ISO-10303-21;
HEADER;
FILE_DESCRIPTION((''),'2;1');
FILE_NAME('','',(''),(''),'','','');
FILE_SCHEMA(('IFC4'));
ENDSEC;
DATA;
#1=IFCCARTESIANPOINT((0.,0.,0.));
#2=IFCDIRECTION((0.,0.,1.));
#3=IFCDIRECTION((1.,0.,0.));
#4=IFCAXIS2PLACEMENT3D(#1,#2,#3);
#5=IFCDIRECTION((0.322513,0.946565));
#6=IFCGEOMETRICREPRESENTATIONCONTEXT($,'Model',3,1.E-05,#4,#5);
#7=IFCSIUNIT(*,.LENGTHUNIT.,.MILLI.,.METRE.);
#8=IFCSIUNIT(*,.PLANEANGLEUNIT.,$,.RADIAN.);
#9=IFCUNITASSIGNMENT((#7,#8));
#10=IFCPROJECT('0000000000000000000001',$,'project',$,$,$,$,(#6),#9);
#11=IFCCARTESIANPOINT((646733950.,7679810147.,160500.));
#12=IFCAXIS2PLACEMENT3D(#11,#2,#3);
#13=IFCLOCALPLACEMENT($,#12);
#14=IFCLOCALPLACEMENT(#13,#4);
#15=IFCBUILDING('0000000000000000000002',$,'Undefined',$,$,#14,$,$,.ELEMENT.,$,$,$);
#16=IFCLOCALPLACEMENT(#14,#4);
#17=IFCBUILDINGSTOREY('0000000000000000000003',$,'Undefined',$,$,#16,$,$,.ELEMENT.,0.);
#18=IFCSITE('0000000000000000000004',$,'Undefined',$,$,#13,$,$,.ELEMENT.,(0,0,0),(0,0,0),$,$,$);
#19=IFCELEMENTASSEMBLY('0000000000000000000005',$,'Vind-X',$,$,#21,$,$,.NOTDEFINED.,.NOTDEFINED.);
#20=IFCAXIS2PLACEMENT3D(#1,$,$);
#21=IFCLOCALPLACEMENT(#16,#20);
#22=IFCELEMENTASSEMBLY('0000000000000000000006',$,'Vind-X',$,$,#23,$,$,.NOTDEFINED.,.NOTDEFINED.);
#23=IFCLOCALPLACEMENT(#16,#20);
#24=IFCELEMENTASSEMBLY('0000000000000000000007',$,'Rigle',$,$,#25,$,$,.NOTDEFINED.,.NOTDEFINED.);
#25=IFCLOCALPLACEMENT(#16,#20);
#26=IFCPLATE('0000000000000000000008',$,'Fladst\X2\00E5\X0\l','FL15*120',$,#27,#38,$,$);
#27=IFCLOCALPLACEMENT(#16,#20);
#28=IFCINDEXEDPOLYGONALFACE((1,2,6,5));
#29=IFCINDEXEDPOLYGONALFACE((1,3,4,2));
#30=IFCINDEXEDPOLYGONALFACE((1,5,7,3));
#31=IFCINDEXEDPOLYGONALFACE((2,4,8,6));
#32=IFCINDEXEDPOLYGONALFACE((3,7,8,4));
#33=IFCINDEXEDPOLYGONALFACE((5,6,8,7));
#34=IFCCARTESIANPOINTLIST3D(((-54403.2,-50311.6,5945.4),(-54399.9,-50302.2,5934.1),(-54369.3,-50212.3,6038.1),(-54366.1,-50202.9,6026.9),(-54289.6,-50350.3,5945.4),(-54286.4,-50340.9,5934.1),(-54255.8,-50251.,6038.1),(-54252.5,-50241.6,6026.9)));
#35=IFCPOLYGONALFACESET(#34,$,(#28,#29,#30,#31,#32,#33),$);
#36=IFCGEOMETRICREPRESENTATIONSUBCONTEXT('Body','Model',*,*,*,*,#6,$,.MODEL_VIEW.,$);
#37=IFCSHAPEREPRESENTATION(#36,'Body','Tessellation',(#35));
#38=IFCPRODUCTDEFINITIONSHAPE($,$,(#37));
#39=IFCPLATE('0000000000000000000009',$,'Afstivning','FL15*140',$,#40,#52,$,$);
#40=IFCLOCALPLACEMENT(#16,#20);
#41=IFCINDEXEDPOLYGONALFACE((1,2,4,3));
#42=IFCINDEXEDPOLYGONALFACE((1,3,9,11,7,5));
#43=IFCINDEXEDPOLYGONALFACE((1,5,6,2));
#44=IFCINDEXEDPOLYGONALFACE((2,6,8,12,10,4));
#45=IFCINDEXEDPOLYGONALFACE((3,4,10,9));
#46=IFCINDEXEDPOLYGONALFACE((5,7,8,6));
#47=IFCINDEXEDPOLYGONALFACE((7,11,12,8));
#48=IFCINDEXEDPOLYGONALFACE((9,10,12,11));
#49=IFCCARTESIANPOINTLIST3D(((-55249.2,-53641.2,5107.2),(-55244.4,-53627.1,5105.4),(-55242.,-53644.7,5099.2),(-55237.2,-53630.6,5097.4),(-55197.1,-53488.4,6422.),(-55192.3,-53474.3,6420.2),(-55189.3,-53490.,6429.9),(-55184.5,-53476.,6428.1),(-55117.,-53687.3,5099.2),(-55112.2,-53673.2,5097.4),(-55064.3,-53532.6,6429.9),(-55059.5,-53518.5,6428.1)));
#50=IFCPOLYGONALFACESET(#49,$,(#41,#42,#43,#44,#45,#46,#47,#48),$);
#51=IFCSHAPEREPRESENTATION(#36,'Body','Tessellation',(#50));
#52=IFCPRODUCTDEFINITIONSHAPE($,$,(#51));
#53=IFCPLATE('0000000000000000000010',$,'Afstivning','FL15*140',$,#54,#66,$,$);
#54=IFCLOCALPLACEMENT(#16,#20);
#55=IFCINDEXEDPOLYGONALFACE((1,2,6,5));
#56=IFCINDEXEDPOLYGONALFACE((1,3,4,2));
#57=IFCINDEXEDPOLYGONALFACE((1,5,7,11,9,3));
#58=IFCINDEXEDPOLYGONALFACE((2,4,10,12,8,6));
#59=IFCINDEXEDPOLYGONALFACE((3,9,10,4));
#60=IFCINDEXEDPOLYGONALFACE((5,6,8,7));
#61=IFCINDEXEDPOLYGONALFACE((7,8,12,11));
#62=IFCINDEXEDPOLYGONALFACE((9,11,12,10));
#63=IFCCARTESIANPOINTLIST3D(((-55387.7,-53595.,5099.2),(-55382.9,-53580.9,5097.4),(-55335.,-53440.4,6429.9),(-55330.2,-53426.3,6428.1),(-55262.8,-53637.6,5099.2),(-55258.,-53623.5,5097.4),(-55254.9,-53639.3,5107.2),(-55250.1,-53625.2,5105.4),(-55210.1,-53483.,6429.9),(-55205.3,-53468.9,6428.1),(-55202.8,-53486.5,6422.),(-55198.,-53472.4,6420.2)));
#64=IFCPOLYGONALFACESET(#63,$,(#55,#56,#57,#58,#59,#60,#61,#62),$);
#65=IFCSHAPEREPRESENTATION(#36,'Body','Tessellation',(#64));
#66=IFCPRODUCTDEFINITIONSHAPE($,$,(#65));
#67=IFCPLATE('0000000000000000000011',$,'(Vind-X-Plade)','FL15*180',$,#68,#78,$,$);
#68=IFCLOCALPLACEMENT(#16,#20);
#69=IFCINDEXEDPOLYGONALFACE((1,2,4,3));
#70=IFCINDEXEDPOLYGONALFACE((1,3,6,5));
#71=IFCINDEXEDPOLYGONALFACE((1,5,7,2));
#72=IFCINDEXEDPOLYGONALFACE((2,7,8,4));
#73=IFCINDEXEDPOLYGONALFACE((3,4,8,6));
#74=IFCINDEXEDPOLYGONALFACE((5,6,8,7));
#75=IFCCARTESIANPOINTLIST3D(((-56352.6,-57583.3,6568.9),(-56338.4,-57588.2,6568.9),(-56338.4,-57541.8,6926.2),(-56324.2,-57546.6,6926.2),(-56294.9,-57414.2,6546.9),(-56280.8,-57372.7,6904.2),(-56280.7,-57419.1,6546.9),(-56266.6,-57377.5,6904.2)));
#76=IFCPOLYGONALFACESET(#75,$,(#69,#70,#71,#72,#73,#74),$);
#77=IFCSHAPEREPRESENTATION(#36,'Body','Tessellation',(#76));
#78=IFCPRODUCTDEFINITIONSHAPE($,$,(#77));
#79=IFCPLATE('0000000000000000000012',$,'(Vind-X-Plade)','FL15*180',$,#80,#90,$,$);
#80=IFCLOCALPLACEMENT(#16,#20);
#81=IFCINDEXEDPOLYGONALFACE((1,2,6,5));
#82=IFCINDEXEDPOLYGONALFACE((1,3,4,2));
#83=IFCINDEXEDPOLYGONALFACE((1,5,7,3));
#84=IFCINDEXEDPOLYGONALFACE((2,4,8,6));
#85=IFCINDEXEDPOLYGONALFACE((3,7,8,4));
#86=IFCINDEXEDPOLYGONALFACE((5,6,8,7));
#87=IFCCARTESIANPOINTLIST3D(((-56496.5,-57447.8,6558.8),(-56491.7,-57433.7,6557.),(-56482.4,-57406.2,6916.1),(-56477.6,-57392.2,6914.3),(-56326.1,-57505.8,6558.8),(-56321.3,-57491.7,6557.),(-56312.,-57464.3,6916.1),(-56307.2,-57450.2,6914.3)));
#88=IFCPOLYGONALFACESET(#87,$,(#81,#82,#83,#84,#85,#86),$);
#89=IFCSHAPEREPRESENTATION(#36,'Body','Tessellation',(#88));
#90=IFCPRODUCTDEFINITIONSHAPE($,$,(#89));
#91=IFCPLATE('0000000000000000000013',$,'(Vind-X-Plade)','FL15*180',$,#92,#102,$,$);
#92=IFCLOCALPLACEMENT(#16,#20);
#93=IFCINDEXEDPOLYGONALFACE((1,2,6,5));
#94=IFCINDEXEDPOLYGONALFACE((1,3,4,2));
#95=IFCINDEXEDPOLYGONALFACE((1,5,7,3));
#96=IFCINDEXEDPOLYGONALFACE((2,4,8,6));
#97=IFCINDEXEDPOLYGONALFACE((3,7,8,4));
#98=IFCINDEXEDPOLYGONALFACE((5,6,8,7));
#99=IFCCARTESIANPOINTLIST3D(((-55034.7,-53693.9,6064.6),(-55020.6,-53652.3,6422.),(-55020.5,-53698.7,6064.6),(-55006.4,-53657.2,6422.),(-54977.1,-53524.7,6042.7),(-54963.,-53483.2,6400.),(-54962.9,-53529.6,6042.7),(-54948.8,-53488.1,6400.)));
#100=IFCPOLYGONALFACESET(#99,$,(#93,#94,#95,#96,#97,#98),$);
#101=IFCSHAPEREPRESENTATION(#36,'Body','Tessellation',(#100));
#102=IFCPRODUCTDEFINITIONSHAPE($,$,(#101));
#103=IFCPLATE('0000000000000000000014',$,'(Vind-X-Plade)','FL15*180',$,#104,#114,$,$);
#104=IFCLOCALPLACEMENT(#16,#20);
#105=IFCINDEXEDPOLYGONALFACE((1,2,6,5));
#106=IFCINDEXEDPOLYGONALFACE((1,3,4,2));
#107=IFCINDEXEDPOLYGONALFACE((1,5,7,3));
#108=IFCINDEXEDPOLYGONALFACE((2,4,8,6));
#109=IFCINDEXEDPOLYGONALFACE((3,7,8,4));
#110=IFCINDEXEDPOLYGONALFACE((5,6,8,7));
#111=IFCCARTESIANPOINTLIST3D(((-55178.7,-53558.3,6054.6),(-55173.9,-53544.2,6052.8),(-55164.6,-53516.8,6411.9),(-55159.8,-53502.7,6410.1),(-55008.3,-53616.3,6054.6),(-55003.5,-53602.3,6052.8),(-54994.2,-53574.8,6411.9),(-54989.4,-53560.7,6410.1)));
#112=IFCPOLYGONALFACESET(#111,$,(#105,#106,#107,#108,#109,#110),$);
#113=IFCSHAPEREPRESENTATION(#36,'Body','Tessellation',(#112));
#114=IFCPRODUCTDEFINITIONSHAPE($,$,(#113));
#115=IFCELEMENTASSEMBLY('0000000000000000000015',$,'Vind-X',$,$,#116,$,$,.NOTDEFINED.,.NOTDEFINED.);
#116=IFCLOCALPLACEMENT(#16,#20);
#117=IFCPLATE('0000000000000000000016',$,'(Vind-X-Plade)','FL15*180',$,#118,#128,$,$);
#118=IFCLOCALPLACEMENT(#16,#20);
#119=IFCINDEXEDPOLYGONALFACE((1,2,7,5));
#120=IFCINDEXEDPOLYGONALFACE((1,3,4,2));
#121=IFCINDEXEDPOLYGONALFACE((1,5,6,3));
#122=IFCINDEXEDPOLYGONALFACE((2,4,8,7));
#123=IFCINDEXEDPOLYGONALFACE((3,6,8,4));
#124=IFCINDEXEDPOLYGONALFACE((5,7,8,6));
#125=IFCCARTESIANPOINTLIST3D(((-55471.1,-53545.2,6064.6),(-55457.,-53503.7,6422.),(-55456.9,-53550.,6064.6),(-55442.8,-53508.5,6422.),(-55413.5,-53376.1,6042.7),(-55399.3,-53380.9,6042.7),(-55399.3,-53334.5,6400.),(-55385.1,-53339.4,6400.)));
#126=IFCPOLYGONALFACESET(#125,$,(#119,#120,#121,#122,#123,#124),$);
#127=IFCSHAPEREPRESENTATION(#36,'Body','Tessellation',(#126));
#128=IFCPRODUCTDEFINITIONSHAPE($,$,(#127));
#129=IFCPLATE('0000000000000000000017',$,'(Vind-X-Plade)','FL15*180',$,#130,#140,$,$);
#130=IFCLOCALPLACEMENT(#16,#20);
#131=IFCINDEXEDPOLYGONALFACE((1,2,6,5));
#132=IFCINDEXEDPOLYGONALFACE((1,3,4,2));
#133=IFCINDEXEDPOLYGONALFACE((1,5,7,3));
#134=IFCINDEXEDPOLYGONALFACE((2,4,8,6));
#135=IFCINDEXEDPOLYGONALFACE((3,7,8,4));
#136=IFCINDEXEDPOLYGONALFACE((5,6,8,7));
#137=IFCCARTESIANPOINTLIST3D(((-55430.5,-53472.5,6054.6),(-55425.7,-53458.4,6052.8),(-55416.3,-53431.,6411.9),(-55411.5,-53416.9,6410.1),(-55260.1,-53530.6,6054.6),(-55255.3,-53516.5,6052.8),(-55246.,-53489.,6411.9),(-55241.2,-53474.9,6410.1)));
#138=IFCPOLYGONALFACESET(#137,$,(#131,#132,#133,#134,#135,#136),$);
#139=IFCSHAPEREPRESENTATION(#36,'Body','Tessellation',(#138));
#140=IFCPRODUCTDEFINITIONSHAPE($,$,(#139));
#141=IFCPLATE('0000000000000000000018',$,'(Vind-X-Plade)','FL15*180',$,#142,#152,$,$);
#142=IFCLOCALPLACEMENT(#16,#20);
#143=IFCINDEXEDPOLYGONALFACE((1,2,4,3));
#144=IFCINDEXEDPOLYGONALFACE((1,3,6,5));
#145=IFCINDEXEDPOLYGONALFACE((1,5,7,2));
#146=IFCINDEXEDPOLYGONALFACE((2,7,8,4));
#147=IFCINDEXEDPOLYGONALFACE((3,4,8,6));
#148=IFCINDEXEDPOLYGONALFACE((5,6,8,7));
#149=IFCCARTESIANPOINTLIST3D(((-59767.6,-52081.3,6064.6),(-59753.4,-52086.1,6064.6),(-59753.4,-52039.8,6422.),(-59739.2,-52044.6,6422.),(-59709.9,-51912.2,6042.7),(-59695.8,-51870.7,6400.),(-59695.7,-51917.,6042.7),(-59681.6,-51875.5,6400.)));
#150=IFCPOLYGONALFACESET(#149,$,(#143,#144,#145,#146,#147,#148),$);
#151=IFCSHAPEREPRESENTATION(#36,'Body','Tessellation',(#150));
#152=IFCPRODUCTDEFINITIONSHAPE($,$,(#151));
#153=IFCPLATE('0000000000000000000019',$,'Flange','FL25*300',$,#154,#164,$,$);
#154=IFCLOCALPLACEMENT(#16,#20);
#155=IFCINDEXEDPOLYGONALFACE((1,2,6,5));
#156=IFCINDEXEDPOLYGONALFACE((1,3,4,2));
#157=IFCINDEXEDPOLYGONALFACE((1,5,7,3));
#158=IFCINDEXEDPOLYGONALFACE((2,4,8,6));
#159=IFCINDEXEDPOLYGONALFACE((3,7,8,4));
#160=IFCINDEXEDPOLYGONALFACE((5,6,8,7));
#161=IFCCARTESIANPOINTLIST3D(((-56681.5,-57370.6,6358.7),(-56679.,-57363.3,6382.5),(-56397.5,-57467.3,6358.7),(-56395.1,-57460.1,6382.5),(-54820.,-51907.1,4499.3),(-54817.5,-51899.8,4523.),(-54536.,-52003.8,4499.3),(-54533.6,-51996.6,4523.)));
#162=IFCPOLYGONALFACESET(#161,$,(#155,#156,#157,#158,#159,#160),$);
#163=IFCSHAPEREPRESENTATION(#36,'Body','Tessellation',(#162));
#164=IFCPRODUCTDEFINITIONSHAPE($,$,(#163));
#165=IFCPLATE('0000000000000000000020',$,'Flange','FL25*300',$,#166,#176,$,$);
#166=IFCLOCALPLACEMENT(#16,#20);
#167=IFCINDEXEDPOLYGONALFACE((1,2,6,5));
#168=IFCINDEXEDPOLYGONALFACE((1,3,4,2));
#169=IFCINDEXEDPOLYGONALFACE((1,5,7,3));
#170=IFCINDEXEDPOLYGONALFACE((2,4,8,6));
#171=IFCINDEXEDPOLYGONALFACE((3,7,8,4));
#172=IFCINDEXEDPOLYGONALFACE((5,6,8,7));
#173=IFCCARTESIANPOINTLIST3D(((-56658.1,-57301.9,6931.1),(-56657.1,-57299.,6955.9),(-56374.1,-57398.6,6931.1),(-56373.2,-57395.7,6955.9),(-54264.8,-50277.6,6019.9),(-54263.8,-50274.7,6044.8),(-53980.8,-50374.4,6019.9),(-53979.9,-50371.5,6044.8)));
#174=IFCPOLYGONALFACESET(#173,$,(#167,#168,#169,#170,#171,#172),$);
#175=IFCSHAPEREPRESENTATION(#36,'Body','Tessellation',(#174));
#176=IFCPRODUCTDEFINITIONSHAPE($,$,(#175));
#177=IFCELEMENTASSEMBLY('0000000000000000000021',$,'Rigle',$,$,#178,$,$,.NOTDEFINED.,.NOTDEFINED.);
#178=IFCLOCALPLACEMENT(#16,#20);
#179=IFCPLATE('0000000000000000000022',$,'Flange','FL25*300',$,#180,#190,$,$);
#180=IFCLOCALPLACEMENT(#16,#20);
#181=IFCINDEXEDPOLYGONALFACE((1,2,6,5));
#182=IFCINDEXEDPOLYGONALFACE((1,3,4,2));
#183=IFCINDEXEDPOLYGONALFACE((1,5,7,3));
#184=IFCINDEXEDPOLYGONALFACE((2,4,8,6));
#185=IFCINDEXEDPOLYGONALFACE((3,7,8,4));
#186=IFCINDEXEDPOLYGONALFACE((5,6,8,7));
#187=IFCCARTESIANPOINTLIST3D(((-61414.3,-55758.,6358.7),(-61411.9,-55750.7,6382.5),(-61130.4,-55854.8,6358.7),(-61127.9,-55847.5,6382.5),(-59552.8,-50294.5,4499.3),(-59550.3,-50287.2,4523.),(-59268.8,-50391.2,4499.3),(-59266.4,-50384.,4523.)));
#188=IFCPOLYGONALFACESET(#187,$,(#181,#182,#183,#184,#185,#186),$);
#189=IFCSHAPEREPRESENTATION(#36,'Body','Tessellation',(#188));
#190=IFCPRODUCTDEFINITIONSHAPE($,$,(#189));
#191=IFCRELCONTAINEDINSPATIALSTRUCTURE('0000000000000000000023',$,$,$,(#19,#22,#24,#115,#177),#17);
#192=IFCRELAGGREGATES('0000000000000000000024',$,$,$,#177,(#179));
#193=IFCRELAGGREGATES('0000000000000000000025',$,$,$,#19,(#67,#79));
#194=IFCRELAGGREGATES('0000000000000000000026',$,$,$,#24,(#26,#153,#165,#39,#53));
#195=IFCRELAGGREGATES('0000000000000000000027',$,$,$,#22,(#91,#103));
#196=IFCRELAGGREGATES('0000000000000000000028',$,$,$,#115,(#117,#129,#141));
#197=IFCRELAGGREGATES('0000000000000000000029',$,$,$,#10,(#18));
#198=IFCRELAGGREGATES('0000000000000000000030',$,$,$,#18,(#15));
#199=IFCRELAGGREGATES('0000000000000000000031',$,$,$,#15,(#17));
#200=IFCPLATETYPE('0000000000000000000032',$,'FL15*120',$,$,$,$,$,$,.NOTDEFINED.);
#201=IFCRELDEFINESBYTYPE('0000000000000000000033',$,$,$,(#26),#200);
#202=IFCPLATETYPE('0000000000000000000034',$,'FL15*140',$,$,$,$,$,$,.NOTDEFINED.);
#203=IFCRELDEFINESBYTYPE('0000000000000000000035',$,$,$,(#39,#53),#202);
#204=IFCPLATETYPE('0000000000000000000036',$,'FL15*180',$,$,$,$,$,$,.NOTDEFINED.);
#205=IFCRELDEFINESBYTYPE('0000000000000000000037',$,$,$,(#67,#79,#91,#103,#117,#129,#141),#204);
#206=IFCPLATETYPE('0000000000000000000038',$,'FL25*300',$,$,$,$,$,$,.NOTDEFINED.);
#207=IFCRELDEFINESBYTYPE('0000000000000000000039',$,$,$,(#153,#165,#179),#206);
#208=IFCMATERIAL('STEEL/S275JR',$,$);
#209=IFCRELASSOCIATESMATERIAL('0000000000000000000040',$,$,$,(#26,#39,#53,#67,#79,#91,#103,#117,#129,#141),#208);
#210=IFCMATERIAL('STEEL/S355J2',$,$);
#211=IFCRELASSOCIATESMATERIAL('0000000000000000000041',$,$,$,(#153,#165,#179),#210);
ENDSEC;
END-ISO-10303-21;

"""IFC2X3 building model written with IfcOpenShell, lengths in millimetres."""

from ifc_helpers import new_model, si_unit, direction, frame, origin_with_axes, place, context, subcontext, project, spatial, polyline, outline, extrude, clip, halfspace, material, type_object, element, aggregate, save


model = new_model("IFC2X3")

# Units and contexts
model_context = context("Model", 3, precision=1e-05, world=origin_with_axes(), true_north=direction((0.322513, 0.946565)))
body_context = subcontext(model_context, "Body", "Model", "MODEL_VIEW")
ifc_project = project(units=[si_unit("LENGTHUNIT", "METRE", prefix="MILLI"), si_unit("PLANEANGLEUNIT", "RADIAN")], contexts=[model_context])

# Site, building, storey
site_placement = place(None, frame((646733950.0, 7679810147.0, 160500.0), z_axis=(0.0, 0.0, 1.0), x_axis=(1.0, 0.0, 0.0)))
site = spatial("IfcSite", under=ifc_project, at=site_placement, Name="Undefined", CompositionType="ELEMENT", RefLatitude=(0, 0, 0), RefLongitude=(0, 0, 0))
building_placement = place(site_placement, origin_with_axes())
building = spatial("IfcBuilding", under=site, at=building_placement, Name="Undefined", CompositionType="ELEMENT")
storey_placement = place(building_placement, origin_with_axes())
storey = spatial("IfcBuildingStorey", under=building, at=storey_placement, Name="Undefined", CompositionType="ELEMENT", Elevation=0.0)

# Element assemblies
assembly_1_placement = place(storey_placement, origin_with_axes())
assembly_1 = element("IfcElementAssembly", 1, at=assembly_1_placement, inside=storey, Name="Vind-X", AssemblyPlace="NOTDEFINED", PredefinedType="NOTDEFINED")
assembly_2_placement = place(storey_placement, origin_with_axes())
assembly_2 = element("IfcElementAssembly", 2, at=assembly_2_placement, inside=storey, Name="Vind-X", AssemblyPlace="NOTDEFINED", PredefinedType="NOTDEFINED")

# Shared definitions
ifc_material_1 = material(Name="STEEL/S355J2")

# Element assembly
assembly_3_placement = place(storey_placement, origin_with_axes())
assembly_3 = element("IfcElementAssembly", 3, at=assembly_3_placement, inside=storey, Name="Rigle", AssemblyPlace="NOTDEFINED", PredefinedType="NOTDEFINED")

# Plates
ifc_material_2 = material(Name="STEEL/S275JR")
plate_type_1 = type_object("IfcPlateType", Name="FL15*120", PredefinedType="NOTDEFINED")
plate_1_placement = place(assembly_3_placement, frame((-54288.0, -50345.6, 5939.7), z_axis=(-0.213703, -0.627213, 0.748956), x_axis=(0.241548, 0.708935, 0.66262)))
plate_1 = element("IfcPlate", 4, at=plate_1_placement, type_object=plate_type_1, material=ifc_material_2, Name="Fladstål", Description="FL15*120", context=body_context, shape_type="SweptSolid", body=[
    extrude(outline(polyline([(0.0, 0.0), (140.0, 0.0), (140.0, 120.0), (0.0, 120.0), (0.0, 0.0)])), frame((0.0, 0.0, -7.5), z_axis=(0.0, 0.0, 1.0), x_axis=(1.0, 0.0, 0.0)), (0.0, 0.0, 1.0), 15.0),
])
plate_type_2 = type_object("IfcPlateType", Name="FL15*140", PredefinedType="NOTDEFINED")
plate_2_placement = place(assembly_3_placement, frame((-55114.6, -53680.2, 5098.3), z_axis=(0.320109, 0.93951, -0.121869), x_axis=(-0.946565, 0.322513, 0.0)))
plate_2 = element("IfcPlate", 5, at=plate_2_placement, type_object=plate_type_2, material=ifc_material_2, Name="Afstivning", Description="FL15*140", context=body_context, shape_type="SweptSolid", body=[
    extrude(outline(polyline([(0.0, 0.0), (132.0, 0.0), (140.0, 8.0), (140.0, 1332.7), (132.0, 1340.7), (0.0, 1340.7), (0.0, 0.0)])), frame((0.0, 0.0, -7.5), z_axis=(0.0, 0.0, 1.0), x_axis=(1.0, 0.0, 0.0)), (0.0, 0.0, 1.0), 15.0),
])
plate_3_placement = place(assembly_3_placement, frame((-55252.8, -53633.1, 5098.3), z_axis=(0.320109, 0.93951, -0.121869), x_axis=(-0.946565, 0.322513, 0.0)))
plate_3 = element("IfcPlate", 6, at=plate_3_placement, type_object=plate_type_2, material=ifc_material_2, Name="Afstivning", Description="FL15*140", context=body_context, shape_type="SweptSolid", body=[
    extrude(outline(polyline([(0.0, 8.0), (8.0, 0.0), (140.0, 0.0), (140.0, 1340.7), (8.0, 1340.7), (0.0, 1332.7), (0.0, 8.0)])), frame((0.0, 0.0, -7.5), z_axis=(0.0, 0.0, 1.0), x_axis=(1.0, 0.0, 0.0)), (0.0, 0.0, 1.0), 15.0),
])
plate_type_3 = type_object("IfcPlateType", Name="FL15*180", PredefinedType="NOTDEFINED")
plate_4_placement = place(assembly_1_placement, frame((-56331.3, -57544.2, 6926.2), z_axis=(-0.946565, 0.322513, 0.0), x_axis=(0.320109, 0.93951, -0.121869)))
plate_4 = element("IfcPlate", 7, at=plate_4_placement, type_object=plate_type_3, material=ifc_material_2, Name="(Vind-X-Plade)", Description="FL15*180", context=body_context, shape_type="SweptSolid", body=[
    extrude(outline(polyline([(0.0, 0.0), (180.0, 0.0), (180.0, 360.0), (0.0, 360.0), (0.0, 0.0)])), frame((0.0, 0.0, -7.5), z_axis=(0.0, 0.0, 1.0), x_axis=(1.0, 0.0, 0.0)), (0.0, 0.0, 1.0), 15.0),
])
plate_5_placement = place(assembly_1_placement, frame((-56494.1, -57440.7, 6557.9), z_axis=(0.320109, 0.93951, -0.121869), x_axis=(0.039304, 0.115357, 0.992546)))
plate_5 = element("IfcPlate", 8, at=plate_5_placement, type_object=plate_type_3, material=ifc_material_2, Name="(Vind-X-Plade)", Description="FL15*180", context=body_context, shape_type="SweptSolid", body=[
    extrude(outline(polyline([(0.0, 0.0), (360.0, 0.0), (360.0, 180.0), (0.0, 180.0), (0.0, 0.0)])), frame((0.0, 0.0, -7.5), z_axis=(0.0, 0.0, 1.0), x_axis=(1.0, 0.0, 0.0)), (0.0, 0.0, 1.0), 15.0),
])
plate_6_placement = place(assembly_2_placement, frame((-55013.5, -53654.7, 6422.0), z_axis=(-0.946565, 0.322513, 0.0), x_axis=(0.320109, 0.93951, -0.121869)))
plate_6 = element("IfcPlate", 9, at=plate_6_placement, type_object=plate_type_3, material=ifc_material_2, Name="(Vind-X-Plade)", Description="FL15*180", context=body_context, shape_type="SweptSolid", body=[
    extrude(outline(polyline([(0.0, 0.0), (180.0, 0.0), (180.0, 360.0), (0.0, 360.0), (0.0, 0.0)])), frame((0.0, 0.0, -7.5), z_axis=(0.0, 0.0, 1.0), x_axis=(1.0, 0.0, 0.0)), (0.0, 0.0, 1.0), 15.0),
])
plate_7_placement = place(assembly_2_placement, frame((-55176.3, -53551.2, 6053.7), z_axis=(0.320109, 0.93951, -0.121869), x_axis=(0.039304, 0.115357, 0.992546)))
plate_7 = element("IfcPlate", 10, at=plate_7_placement, type_object=plate_type_3, material=ifc_material_2, Name="(Vind-X-Plade)", Description="FL15*180", context=body_context, shape_type="SweptSolid", body=[
    extrude(outline(polyline([(0.0, 0.0), (360.0, 0.0), (360.0, 180.0), (0.0, 180.0), (0.0, 0.0)])), frame((0.0, 0.0, -7.5), z_axis=(0.0, 0.0, 1.0), x_axis=(1.0, 0.0, 0.0)), (0.0, 0.0, 1.0), 15.0),
])

# Element assembly, plates
assembly_4_placement = place(storey_placement, origin_with_axes())
assembly_4 = element("IfcElementAssembly", 11, at=assembly_4_placement, inside=storey, Name="Vind-X", AssemblyPlace="NOTDEFINED", PredefinedType="NOTDEFINED")
plate_8_placement = place(assembly_4_placement, frame((-55392.2, -53337.0, 6400.0), z_axis=(0.946565, -0.322513, 0.0), x_axis=(-0.320109, -0.93951, 0.121869)))
plate_8 = element("IfcPlate", 12, at=plate_8_placement, type_object=plate_type_3, material=ifc_material_2, Name="(Vind-X-Plade)", Description="FL15*180", context=body_context, shape_type="SweptSolid", body=[
    extrude(outline(polyline([(0.0, 0.0), (180.0, 0.0), (180.0, 360.0), (0.0, 360.0), (0.0, 0.0)])), frame((0.0, 0.0, -7.5), z_axis=(0.0, 0.0, 1.0), x_axis=(1.0, 0.0, 0.0)), (0.0, 0.0, 1.0), 15.0),
])
plate_9_placement = place(assembly_4_placement, frame((-55257.7, -53523.5, 6053.7), z_axis=(-0.320109, -0.93951, 0.121869), x_axis=(0.039304, 0.115357, 0.992546)))
plate_9 = element("IfcPlate", 13, at=plate_9_placement, type_object=plate_type_3, material=ifc_material_2, Name="(Vind-X-Plade)", Description="FL15*180", context=body_context, shape_type="SweptSolid", body=[
    extrude(outline(polyline([(0.0, 0.0), (360.0, 0.0), (360.0, 180.0), (0.0, 180.0), (0.0, 0.0)])), frame((0.0, 0.0, -7.5), z_axis=(0.0, 0.0, 1.0), x_axis=(1.0, 0.0, 0.0)), (0.0, 0.0, 1.0), 15.0),
])
plate_10_placement = place(assembly_4_placement, frame((-59746.3, -52042.2, 6422.0), z_axis=(-0.946565, 0.322513, 0.0), x_axis=(0.320109, 0.93951, -0.121869)))
plate_10 = element("IfcPlate", 14, at=plate_10_placement, type_object=plate_type_3, material=ifc_material_2, Name="(Vind-X-Plade)", Description="FL15*180", context=body_context, shape_type="SweptSolid", body=[
    extrude(outline(polyline([(0.0, 0.0), (180.0, 0.0), (180.0, 360.0), (0.0, 360.0), (0.0, 0.0)])), frame((0.0, 0.0, -7.5), z_axis=(0.0, 0.0, 1.0), x_axis=(1.0, 0.0, 0.0)), (0.0, 0.0, 1.0), 15.0),
])

# Plates
plate_type_4 = type_object("IfcPlateType", Name="FL25*300", PredefinedType="NOTDEFINED")
plate_11_placement = place(assembly_3_placement, frame((-54676.8, -51951.8, 4511.2), z_axis=(-0.098895, -0.290253, -0.951826), x_axis=(-0.306976, -0.900965, 0.306638)))
plate_11 = element("IfcPlate", 15, at=plate_11_placement, type_object=plate_type_4, material=ifc_material_1, Name="Flange", Description="FL25*300", context=body_context, shape_type="Clipping", body=[
    clip(extrude(outline(polyline([(0.0, -150.0), (0.0, 150.0), (6064.1, 150.0), (6064.1, -150.0), (0.0, -150.0)])), frame((0.0, 0.0, -12.5), z_axis=(0.0, 0.0, 1.0), x_axis=(1.0, 0.0, 0.0)), (0.0, 0.0, 1.0), 25.0), halfspace(frame((6064.1, 0.0, 0.3), z_axis=(1.0, 0.0, 0.0), x_axis=(0.0, 1.0, 0.0)), False)),
])
plate_12_placement = place(assembly_3_placement, frame((-54122.3, -50324.5, 6032.4), z_axis=(-0.039304, -0.115357, -0.992546), x_axis=(-0.320109, -0.93951, 0.121869)))
plate_12 = element("IfcPlate", 16, at=plate_12_placement, type_object=plate_type_4, material=ifc_material_1, Name="Flange", Description="FL25*300", context=body_context, shape_type="Clipping", body=[
    clip(extrude(outline(polyline([(0.0, -150.0), (0.0, 150.0), (7476.5, 150.0), (7476.5, -150.0), (0.0, -150.0)])), frame((0.0, 0.0, -12.5), z_axis=(0.0, 0.0, 1.0), x_axis=(1.0, 0.0, 0.0)), (0.0, 0.0, 1.0), 25.0), halfspace(frame((7476.5, 0.0, 287.5), z_axis=(1.0, 0.0, 0.0), x_axis=(0.0, 1.0, 0.0)), False)),
])

# Element assembly, plate
assembly_5_placement = place(storey_placement, origin_with_axes())
assembly_5 = element("IfcElementAssembly", 17, at=assembly_5_placement, inside=storey, Name="Rigle", AssemblyPlace="NOTDEFINED", PredefinedType="NOTDEFINED")
plate_13_placement = place(assembly_5_placement, frame((-59409.6, -50339.2, 4511.2), z_axis=(-0.098895, -0.290253, -0.951826), x_axis=(-0.306976, -0.900965, 0.306638)))
plate_13 = element("IfcPlate", 18, at=plate_13_placement, type_object=plate_type_4, material=ifc_material_1, Name="Flange", Description="FL25*300", context=body_context, shape_type="Clipping", body=[
    clip(extrude(outline(polyline([(0.0, -150.0), (0.0, 150.0), (6064.1, 150.0), (6064.1, -150.0), (0.0, -150.0)])), frame((0.0, 0.0, -12.5), z_axis=(0.0, 0.0, 1.0), x_axis=(1.0, 0.0, 0.0)), (0.0, 0.0, 1.0), 25.0), halfspace(frame((6064.1, 0.0, 0.3), z_axis=(1.0, 0.0, 0.0), x_axis=(0.0, 1.0, 0.0)), False)),
])
aggregate(assembly_5, [plate_13])

aggregate(assembly_1, [plate_4, plate_5])
aggregate(assembly_3, [plate_1, plate_11, plate_12, plate_2, plate_3])
aggregate(assembly_2, [plate_6, plate_7])
aggregate(assembly_4, [plate_8, plate_9, plate_10])

save(model, "model.ifc")
